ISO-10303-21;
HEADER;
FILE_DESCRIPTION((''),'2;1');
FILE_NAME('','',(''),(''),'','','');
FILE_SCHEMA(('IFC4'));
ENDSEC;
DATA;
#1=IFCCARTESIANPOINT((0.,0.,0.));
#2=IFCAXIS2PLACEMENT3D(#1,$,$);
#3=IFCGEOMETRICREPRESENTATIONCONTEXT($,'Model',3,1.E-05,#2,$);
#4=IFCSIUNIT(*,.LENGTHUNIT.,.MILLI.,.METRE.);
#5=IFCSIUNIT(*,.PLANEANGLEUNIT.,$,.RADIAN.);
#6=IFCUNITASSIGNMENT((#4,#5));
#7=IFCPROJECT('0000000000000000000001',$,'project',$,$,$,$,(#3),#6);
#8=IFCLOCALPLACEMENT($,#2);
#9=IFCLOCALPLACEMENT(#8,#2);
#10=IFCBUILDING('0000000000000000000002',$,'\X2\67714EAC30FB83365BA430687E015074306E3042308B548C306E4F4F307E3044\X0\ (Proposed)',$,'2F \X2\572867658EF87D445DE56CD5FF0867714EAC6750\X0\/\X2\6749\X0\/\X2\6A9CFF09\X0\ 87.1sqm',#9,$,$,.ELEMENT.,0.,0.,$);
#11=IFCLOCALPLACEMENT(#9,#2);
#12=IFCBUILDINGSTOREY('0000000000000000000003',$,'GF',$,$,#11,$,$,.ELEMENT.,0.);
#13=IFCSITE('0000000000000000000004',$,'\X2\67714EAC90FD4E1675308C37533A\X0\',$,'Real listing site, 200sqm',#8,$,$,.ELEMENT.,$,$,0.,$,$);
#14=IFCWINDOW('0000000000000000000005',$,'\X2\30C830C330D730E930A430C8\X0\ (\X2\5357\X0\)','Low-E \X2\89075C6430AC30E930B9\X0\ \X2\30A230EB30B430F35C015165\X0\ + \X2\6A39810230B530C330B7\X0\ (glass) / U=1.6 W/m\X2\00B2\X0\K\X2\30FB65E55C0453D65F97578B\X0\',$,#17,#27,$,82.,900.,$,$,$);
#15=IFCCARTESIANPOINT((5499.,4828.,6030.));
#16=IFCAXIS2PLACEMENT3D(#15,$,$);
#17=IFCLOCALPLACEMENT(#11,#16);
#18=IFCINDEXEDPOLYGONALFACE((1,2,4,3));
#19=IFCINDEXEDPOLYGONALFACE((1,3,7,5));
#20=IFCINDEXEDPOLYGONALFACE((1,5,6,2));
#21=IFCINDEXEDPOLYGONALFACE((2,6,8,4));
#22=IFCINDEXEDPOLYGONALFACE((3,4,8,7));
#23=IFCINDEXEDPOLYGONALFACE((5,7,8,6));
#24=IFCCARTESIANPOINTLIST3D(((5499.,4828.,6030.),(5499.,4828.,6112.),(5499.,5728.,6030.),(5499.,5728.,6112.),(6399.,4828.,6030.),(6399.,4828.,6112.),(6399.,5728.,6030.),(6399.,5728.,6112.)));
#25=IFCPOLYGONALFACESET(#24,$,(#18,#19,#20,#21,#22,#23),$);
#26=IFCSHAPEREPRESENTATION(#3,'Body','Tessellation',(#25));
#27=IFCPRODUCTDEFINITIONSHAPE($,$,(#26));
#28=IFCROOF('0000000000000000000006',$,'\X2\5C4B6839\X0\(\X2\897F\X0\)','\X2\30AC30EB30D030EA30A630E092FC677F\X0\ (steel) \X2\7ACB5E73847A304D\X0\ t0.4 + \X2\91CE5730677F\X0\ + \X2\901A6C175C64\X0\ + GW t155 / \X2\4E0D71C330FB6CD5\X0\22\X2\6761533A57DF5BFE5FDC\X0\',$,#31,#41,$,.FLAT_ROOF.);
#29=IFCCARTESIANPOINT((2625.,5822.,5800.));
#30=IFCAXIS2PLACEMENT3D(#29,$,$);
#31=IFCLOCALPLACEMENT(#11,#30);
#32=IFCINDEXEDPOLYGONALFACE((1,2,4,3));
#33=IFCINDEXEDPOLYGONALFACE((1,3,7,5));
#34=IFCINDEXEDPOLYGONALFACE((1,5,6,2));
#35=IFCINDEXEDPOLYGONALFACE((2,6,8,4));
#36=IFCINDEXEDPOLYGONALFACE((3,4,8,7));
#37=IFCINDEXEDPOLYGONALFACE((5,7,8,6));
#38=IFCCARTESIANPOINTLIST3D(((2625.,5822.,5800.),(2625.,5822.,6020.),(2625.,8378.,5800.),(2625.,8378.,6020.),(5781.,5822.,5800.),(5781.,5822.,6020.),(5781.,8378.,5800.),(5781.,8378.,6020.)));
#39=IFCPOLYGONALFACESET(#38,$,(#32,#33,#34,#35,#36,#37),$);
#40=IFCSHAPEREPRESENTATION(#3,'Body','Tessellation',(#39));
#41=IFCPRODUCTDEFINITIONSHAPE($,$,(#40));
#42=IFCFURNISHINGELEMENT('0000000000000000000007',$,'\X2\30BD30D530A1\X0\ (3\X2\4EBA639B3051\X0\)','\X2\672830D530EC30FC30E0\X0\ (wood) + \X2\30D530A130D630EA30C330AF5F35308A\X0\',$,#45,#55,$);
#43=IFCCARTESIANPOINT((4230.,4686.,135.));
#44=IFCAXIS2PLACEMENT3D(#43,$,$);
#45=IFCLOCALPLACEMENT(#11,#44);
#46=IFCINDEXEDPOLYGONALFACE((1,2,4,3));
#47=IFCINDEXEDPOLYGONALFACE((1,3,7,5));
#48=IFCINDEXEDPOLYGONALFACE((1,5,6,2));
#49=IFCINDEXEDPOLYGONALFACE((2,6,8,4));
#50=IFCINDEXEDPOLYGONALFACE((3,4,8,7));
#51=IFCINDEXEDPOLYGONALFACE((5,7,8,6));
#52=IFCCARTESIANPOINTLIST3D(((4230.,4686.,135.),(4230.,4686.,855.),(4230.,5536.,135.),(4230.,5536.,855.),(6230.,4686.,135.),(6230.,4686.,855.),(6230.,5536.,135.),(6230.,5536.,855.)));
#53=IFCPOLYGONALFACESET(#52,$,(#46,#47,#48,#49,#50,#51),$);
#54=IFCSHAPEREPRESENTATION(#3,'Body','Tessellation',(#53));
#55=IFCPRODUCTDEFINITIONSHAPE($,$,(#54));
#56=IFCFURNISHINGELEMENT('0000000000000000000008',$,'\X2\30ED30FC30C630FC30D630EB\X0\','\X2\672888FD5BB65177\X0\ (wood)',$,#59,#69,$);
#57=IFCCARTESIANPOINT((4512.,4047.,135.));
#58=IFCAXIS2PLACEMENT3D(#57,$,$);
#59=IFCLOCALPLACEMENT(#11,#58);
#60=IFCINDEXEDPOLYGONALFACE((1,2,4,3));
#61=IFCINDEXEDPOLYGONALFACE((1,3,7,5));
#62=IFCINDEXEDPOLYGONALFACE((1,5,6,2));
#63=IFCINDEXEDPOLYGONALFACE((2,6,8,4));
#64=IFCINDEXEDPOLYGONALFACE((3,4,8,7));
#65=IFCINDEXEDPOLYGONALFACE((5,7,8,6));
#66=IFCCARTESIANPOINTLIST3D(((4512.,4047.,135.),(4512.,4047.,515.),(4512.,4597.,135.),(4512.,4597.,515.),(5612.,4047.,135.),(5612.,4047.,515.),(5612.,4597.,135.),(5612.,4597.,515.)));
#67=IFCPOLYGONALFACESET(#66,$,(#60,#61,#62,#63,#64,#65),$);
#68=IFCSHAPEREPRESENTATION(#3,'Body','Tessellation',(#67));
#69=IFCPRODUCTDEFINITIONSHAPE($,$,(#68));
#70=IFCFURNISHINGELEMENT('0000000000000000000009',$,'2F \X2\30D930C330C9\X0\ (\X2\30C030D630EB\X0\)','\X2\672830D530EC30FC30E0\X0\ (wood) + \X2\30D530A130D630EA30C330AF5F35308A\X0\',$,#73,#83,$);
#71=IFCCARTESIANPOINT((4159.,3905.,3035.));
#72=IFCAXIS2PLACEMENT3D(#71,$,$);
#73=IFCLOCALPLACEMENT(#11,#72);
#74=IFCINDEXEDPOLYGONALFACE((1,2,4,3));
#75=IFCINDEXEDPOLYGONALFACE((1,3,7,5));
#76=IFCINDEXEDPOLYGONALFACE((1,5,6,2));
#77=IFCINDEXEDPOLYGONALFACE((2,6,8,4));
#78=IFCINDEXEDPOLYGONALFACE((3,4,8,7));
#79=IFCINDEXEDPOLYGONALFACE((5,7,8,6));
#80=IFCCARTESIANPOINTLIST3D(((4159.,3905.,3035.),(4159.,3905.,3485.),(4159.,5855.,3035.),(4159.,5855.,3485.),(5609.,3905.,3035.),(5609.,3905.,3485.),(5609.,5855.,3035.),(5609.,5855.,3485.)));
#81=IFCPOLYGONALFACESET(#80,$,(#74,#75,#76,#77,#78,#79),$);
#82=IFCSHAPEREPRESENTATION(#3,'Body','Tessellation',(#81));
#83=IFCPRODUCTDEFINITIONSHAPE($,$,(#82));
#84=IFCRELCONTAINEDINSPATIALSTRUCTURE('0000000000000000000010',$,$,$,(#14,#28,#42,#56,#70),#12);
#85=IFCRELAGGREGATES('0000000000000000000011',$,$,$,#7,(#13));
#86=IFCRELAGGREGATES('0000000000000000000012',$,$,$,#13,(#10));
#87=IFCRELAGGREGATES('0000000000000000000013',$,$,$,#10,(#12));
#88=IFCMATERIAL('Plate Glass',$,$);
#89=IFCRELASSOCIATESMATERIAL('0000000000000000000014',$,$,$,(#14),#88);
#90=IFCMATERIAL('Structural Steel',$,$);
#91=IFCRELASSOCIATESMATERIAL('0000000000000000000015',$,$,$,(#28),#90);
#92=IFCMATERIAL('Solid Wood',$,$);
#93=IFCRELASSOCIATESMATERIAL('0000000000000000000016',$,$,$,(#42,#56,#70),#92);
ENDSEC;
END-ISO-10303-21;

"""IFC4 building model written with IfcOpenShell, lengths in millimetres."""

from ifc_helpers import new_model, si_unit, frame, frame_2d, origin, place, context, project, spatial, rectangle, extrude, material, element, save


model = new_model("IFC4")

# Units and contexts
model_context = context("Model", 3, precision=1e-05, world=origin())
ifc_project = project(units=[si_unit("LENGTHUNIT", "METRE", prefix="MILLI"), si_unit("PLANEANGLEUNIT", "RADIAN")], contexts=[model_context])

# Site, building, storey
site_placement = place(None, origin())
site = spatial("IfcSite", under=ifc_project, at=site_placement, Name="東京都世田谷区", ObjectType="Real listing site, 200sqm", CompositionType="ELEMENT", RefElevation=0.0)
building_placement = place(site_placement, origin())
building = spatial("IfcBuilding", under=site, at=building_placement, Name="東京・茶室と縁側のある和の住まい (Proposed)", ObjectType="2F 在来軸組工法（東京材/杉/檜） 87.1sqm", CompositionType="ELEMENT", ElevationOfRefHeight=0.0, ElevationOfTerrain=0.0)
storey_placement = place(building_placement, origin())
storey = spatial("IfcBuildingStorey", under=building, at=storey_placement, Name="GF", CompositionType="ELEMENT", Elevation=0.0)

# Shared definitions
ifc_material_1 = material(Name="Solid Wood")

# Window
ifc_material_2 = material(Name="Plate Glass")
window_placement = place(storey_placement, frame((5499.0, 4828.0, 6030.0)))
element("IfcWindow", 1, at=window_placement, inside=storey, material=ifc_material_2, Name="トップライト (南)", Description="Low-E 複層ガラス アルゴン封入 + 樹脂サッシ (glass) / U=1.6 W/m²K・日射取得型", OverallHeight=82.0, OverallWidth=900.0, context=model_context, shape_type="SweptSolid", body=[
    extrude(rectangle(XDim=900.0, YDim=900.0, at=frame_2d((450.0, 450.0))), frame((5499.0, 4828.0, 6030.0)), (0.0, 0.0, 1.0), 82.0),
])

# Roof
ifc_material_3 = material(Name="Structural Steel")
for number, where, name in (
    (2, (2625.0, 5822.0, 5800.0), "屋根(西)"),
):
    element("IfcRoof", number, at=place(storey_placement, frame(where)), inside=storey, material=ifc_material_3, Name=name, Description="ガルバリウム鋼板 (steel) 立平葺き t0.4 + 野地板 + 通気層 + GW t155 / 不燃・法22条区域対応", PredefinedType="FLAT_ROOF", context=model_context, shape_type="SweptSolid", body=[
        extrude(rectangle(XDim=3156.0, YDim=2556.0, at=frame_2d((1578.0, 1278.0))), frame((2625.0, 5822.0, 5800.0)), (0.0, 0.0, 1.0), 220.0),
    ])

# Furnishing elements
furnishing_1_placement = place(storey_placement, frame((4230.0, 4686.0, 135.0)))
element("IfcFurnishingElement", 3, at=furnishing_1_placement, inside=storey, material=ifc_material_1, Name="ソファ (3人掛け)", Description="木フレーム (wood) + ファブリック張り", context=model_context, shape_type="SweptSolid", body=[
    extrude(rectangle(XDim=2000.0, YDim=850.0, at=frame_2d((1000.0, 425.0))), frame((4230.0, 4686.0, 135.0)), (0.0, 0.0, 1.0), 720.0),
])
furnishing_2_placement = place(storey_placement, frame((4512.0, 4047.0, 135.0)))
element("IfcFurnishingElement", 4, at=furnishing_2_placement, inside=storey, material=ifc_material_1, Name="ローテーブル", Description="木製家具 (wood)", context=model_context, shape_type="SweptSolid", body=[
    extrude(rectangle(XDim=1100.0, YDim=550.0, at=frame_2d((550.0, 275.0))), frame((4512.0, 4047.0, 135.0)), (0.0, 0.0, 1.0), 380.0),
])
furnishing_3_placement = place(storey_placement, frame((4159.0, 3905.0, 3035.0)))
element("IfcFurnishingElement", 5, at=furnishing_3_placement, inside=storey, material=ifc_material_1, Name="2F ベッド (ダブル)", Description="木フレーム (wood) + ファブリック張り", context=model_context, shape_type="SweptSolid", body=[
    extrude(rectangle(XDim=1450.0, YDim=1950.0, at=frame_2d((725.0, 975.0))), frame((4159.0, 3905.0, 3035.0)), (0.0, 0.0, 1.0), 450.0),
])

save(model, "model.ifc")
